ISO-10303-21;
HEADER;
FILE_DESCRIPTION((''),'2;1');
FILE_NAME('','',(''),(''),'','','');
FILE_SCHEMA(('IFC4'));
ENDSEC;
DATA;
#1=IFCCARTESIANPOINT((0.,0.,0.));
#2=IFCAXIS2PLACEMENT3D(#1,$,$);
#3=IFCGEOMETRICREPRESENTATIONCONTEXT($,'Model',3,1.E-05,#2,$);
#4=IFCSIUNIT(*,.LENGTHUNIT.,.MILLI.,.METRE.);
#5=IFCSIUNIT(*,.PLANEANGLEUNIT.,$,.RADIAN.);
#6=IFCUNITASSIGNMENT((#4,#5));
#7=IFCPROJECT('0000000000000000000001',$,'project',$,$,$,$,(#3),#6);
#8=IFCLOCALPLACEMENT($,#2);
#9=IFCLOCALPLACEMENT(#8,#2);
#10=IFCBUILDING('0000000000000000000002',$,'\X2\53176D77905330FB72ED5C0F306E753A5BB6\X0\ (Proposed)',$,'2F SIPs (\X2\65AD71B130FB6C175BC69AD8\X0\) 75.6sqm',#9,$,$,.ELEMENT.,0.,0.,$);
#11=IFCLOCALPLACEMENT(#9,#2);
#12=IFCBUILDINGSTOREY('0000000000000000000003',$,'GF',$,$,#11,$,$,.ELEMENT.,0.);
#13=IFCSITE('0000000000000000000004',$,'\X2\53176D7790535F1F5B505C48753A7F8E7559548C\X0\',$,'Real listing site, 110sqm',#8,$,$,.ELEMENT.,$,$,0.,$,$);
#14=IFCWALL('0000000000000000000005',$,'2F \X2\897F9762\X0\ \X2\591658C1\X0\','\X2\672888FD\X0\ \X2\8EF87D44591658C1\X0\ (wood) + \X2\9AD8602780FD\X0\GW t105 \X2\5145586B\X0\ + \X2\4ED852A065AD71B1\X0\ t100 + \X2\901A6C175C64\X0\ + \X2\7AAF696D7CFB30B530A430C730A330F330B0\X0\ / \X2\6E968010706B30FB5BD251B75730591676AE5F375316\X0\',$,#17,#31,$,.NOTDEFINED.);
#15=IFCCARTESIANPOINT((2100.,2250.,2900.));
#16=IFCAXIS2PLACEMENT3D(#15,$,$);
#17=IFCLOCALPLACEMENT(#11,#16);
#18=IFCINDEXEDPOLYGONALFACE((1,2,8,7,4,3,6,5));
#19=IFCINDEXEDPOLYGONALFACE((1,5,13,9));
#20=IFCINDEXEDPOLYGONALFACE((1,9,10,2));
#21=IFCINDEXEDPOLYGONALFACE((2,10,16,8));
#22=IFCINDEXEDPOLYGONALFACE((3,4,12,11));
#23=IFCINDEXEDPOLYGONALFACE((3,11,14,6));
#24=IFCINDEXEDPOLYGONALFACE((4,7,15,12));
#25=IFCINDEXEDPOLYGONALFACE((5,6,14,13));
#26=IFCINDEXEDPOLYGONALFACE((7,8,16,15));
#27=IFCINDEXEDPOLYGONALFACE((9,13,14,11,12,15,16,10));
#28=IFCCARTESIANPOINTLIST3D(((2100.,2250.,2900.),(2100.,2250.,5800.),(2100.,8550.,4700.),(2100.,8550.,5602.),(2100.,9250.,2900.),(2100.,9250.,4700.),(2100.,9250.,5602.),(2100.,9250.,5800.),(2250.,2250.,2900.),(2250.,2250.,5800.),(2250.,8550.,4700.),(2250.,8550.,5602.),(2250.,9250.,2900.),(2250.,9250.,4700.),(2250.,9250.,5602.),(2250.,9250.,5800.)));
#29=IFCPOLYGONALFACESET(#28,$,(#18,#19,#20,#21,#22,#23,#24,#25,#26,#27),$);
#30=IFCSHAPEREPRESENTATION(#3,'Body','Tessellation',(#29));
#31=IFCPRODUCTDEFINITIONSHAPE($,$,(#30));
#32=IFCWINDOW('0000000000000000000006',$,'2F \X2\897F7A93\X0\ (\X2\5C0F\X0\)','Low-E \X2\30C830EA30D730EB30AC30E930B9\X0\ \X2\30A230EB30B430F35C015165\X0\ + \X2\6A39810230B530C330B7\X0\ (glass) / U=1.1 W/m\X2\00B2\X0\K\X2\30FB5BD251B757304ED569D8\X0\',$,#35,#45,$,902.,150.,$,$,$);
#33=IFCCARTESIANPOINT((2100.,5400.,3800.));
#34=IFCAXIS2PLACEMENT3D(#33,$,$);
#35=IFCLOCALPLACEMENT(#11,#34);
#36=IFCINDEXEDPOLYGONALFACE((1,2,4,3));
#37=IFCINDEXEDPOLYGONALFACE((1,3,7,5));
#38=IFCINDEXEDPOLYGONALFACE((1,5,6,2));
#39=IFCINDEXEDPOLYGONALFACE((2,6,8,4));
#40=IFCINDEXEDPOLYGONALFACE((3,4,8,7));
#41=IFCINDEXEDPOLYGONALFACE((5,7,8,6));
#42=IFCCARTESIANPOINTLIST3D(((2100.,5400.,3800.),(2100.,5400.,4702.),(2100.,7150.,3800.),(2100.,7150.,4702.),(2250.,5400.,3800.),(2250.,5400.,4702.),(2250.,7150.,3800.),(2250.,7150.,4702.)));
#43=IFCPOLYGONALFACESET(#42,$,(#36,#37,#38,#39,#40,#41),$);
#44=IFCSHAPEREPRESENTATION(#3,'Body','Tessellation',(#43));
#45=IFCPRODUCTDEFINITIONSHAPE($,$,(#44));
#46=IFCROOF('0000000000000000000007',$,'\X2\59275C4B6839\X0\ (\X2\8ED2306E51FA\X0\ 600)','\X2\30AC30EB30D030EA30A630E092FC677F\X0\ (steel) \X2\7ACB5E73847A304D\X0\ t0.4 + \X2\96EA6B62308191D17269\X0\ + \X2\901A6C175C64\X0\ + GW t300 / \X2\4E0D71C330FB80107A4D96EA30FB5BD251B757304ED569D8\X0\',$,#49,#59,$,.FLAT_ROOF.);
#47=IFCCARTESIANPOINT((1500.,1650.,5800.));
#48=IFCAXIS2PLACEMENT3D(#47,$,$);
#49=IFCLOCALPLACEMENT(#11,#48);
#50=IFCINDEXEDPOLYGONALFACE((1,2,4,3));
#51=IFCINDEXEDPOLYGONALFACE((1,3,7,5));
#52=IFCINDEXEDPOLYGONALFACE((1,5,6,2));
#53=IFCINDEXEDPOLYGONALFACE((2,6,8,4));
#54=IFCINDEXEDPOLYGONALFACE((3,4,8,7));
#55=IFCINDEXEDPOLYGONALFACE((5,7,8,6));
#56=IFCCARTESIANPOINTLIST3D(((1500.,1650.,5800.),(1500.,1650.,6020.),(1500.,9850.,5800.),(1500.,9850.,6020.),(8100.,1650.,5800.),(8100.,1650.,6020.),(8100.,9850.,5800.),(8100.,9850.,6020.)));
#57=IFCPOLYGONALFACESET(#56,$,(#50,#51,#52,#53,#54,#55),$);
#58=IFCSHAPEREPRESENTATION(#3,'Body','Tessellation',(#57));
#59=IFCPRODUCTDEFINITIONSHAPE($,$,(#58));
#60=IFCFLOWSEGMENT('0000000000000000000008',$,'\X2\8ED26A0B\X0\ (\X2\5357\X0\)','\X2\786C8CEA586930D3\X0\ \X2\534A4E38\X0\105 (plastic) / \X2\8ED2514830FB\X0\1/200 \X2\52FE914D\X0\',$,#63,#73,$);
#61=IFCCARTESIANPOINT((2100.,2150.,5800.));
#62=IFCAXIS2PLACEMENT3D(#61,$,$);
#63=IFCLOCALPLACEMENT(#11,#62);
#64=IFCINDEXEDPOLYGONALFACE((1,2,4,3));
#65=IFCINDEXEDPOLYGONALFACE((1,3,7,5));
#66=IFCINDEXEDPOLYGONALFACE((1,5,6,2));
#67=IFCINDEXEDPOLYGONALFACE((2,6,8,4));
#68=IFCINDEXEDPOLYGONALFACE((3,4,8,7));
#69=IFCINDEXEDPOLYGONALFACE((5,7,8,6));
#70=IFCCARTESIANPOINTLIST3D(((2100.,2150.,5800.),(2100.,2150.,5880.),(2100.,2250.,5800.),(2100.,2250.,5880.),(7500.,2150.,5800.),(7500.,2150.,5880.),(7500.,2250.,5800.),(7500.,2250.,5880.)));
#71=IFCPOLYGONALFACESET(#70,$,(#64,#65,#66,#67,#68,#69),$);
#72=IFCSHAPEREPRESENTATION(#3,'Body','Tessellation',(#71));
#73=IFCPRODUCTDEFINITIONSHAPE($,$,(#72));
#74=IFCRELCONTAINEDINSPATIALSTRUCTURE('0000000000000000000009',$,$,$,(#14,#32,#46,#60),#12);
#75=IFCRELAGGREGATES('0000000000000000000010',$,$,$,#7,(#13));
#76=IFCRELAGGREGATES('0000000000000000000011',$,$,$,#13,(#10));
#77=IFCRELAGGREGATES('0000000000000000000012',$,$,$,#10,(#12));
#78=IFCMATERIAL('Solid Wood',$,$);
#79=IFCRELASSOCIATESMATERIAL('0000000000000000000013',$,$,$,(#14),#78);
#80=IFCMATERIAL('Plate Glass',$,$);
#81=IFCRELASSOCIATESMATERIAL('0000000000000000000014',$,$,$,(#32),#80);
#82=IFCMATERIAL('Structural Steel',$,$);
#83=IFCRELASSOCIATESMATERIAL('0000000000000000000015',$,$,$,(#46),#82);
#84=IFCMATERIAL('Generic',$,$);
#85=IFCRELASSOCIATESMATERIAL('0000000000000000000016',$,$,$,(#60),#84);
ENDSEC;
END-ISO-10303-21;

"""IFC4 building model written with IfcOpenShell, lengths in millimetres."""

from ifc_helpers import new_model, si_unit, frame, frame_2d, origin, place, context, project, spatial, rectangle, extrude, material, element, fill, save


model = new_model("IFC4")

# Units and contexts
model_context = context("Model", 3, precision=1e-05, world=origin())
ifc_project = project(units=[si_unit("LENGTHUNIT", "METRE", prefix="MILLI"), si_unit("PLANEANGLEUNIT", "RADIAN")], contexts=[model_context])

# Site, building, storey
site_placement = place(None, origin())
site = spatial("IfcSite", under=ifc_project, at=site_placement, Name="北海道弟子屈町美留和", ObjectType="Real listing site, 110sqm", CompositionType="ELEMENT", RefElevation=0.0)
building_placement = place(site_placement, origin())
building = spatial("IfcBuilding", under=site, at=building_placement, Name="北海道・狭小の町家 (Proposed)", ObjectType="2F SIPs (断熱・気密高) 75.6sqm", CompositionType="ELEMENT", ElevationOfRefHeight=0.0, ElevationOfTerrain=0.0)
storey_placement = place(building_placement, origin())
storey = spatial("IfcBuildingStorey", under=building, at=storey_placement, Name="GF", CompositionType="ELEMENT", Elevation=0.0)

# Shared definitions
ifc_material_1 = material(Name="Solid Wood")

# Shared definitions
ifc_material_2 = material(Name="Plate Glass")

# Wall, opening, window
wall_1_placement = place(storey_placement, frame((2100.0, 2250.0, 2900.0)))
wall_1 = element("IfcWall", 1, at=wall_1_placement, inside=storey, material=ifc_material_1, Name="2F 西面 外壁", Description="木製 軸組外壁 (wood) + 高性能GW t105 充填 + 付加断熱 t100 + 通気層 + 窯業系サイディング / 準耐火・寒冷地外皮強化", PredefinedType="NOTDEFINED", context=model_context, shape_type="SweptSolid", body=[
    extrude(rectangle(XDim=150.0, YDim=7000.0, at=frame_2d((75.0, 3500.0))), frame((2100.0, 2250.0, 2900.0)), (0.0, 0.0, 1.0), 2900.0),
])
opening_1_placement = place(storey_placement, frame((2100.0, 5400.0, 3800.0)))
opening_1 = element("IfcOpeningElement", 2, at=opening_1_placement, cuts=wall_1, PredefinedType="NOTDEFINED", context=model_context, shape_type="SweptSolid", body=[
    extrude(rectangle(XDim=150.0, YDim=1750.0, at=frame_2d((75.0, 875.0))), frame((2100.0, 5400.0, 3800.0)), (0.0, 0.0, 1.0), 902.0),
])
window_1_placement = place(storey_placement, frame((2100.0, 5400.0, 3800.0)))
window_1 = element("IfcWindow", 3, at=window_1_placement, inside=storey, material=ifc_material_2, Name="2F 西窓 (小)", Description="Low-E トリプルガラス アルゴン封入 + 樹脂サッシ (glass) / U=1.1 W/m²K・寒冷地仕様", OverallHeight=902.0, OverallWidth=150.0, context=model_context, shape_type="SweptSolid", body=[
    extrude(rectangle(XDim=150.0, YDim=1750.0, at=frame_2d((75.0, 875.0))), frame((2100.0, 5400.0, 3800.0)), (0.0, 0.0, 1.0), 902.0),
])
fill(opening_1, window_1)

# Roof
ifc_material_3 = material(Name="Structural Steel")
roof_placement = place(storey_placement, frame((1500.0, 1650.0, 5800.0)))
element("IfcRoof", 4, at=roof_placement, inside=storey, material=ifc_material_3, Name="大屋根 (軒の出 600)", Description="ガルバリウム鋼板 (steel) 立平葺き t0.4 + 雪止め金物 + 通気層 + GW t300 / 不燃・耐積雪・寒冷地仕様", PredefinedType="FLAT_ROOF", context=model_context, shape_type="SweptSolid", body=[
    extrude(rectangle(XDim=6600.0, YDim=8200.0, at=frame_2d((3300.0, 4100.0))), frame((1500.0, 1650.0, 5800.0)), (0.0, 0.0, 1.0), 220.0),
])

# Flow segment
ifc_material_4 = material(Name="Generic")
flow_segment_placement = place(storey_placement, frame((2100.0, 2150.0, 5800.0)))
element("IfcFlowSegment", 5, at=flow_segment_placement, inside=storey, material=ifc_material_4, Name="軒樋 (南)", Description="硬質塩ビ 半丸105 (plastic) / 軒先・1/200 勾配", context=model_context, shape_type="SweptSolid", body=[
    extrude(rectangle(XDim=5400.0, YDim=100.0, at=frame_2d((2700.0, 50.0))), frame((2100.0, 2150.0, 5800.0)), (0.0, 0.0, 1.0), 80.0),
])

save(model, "model.ifc")
